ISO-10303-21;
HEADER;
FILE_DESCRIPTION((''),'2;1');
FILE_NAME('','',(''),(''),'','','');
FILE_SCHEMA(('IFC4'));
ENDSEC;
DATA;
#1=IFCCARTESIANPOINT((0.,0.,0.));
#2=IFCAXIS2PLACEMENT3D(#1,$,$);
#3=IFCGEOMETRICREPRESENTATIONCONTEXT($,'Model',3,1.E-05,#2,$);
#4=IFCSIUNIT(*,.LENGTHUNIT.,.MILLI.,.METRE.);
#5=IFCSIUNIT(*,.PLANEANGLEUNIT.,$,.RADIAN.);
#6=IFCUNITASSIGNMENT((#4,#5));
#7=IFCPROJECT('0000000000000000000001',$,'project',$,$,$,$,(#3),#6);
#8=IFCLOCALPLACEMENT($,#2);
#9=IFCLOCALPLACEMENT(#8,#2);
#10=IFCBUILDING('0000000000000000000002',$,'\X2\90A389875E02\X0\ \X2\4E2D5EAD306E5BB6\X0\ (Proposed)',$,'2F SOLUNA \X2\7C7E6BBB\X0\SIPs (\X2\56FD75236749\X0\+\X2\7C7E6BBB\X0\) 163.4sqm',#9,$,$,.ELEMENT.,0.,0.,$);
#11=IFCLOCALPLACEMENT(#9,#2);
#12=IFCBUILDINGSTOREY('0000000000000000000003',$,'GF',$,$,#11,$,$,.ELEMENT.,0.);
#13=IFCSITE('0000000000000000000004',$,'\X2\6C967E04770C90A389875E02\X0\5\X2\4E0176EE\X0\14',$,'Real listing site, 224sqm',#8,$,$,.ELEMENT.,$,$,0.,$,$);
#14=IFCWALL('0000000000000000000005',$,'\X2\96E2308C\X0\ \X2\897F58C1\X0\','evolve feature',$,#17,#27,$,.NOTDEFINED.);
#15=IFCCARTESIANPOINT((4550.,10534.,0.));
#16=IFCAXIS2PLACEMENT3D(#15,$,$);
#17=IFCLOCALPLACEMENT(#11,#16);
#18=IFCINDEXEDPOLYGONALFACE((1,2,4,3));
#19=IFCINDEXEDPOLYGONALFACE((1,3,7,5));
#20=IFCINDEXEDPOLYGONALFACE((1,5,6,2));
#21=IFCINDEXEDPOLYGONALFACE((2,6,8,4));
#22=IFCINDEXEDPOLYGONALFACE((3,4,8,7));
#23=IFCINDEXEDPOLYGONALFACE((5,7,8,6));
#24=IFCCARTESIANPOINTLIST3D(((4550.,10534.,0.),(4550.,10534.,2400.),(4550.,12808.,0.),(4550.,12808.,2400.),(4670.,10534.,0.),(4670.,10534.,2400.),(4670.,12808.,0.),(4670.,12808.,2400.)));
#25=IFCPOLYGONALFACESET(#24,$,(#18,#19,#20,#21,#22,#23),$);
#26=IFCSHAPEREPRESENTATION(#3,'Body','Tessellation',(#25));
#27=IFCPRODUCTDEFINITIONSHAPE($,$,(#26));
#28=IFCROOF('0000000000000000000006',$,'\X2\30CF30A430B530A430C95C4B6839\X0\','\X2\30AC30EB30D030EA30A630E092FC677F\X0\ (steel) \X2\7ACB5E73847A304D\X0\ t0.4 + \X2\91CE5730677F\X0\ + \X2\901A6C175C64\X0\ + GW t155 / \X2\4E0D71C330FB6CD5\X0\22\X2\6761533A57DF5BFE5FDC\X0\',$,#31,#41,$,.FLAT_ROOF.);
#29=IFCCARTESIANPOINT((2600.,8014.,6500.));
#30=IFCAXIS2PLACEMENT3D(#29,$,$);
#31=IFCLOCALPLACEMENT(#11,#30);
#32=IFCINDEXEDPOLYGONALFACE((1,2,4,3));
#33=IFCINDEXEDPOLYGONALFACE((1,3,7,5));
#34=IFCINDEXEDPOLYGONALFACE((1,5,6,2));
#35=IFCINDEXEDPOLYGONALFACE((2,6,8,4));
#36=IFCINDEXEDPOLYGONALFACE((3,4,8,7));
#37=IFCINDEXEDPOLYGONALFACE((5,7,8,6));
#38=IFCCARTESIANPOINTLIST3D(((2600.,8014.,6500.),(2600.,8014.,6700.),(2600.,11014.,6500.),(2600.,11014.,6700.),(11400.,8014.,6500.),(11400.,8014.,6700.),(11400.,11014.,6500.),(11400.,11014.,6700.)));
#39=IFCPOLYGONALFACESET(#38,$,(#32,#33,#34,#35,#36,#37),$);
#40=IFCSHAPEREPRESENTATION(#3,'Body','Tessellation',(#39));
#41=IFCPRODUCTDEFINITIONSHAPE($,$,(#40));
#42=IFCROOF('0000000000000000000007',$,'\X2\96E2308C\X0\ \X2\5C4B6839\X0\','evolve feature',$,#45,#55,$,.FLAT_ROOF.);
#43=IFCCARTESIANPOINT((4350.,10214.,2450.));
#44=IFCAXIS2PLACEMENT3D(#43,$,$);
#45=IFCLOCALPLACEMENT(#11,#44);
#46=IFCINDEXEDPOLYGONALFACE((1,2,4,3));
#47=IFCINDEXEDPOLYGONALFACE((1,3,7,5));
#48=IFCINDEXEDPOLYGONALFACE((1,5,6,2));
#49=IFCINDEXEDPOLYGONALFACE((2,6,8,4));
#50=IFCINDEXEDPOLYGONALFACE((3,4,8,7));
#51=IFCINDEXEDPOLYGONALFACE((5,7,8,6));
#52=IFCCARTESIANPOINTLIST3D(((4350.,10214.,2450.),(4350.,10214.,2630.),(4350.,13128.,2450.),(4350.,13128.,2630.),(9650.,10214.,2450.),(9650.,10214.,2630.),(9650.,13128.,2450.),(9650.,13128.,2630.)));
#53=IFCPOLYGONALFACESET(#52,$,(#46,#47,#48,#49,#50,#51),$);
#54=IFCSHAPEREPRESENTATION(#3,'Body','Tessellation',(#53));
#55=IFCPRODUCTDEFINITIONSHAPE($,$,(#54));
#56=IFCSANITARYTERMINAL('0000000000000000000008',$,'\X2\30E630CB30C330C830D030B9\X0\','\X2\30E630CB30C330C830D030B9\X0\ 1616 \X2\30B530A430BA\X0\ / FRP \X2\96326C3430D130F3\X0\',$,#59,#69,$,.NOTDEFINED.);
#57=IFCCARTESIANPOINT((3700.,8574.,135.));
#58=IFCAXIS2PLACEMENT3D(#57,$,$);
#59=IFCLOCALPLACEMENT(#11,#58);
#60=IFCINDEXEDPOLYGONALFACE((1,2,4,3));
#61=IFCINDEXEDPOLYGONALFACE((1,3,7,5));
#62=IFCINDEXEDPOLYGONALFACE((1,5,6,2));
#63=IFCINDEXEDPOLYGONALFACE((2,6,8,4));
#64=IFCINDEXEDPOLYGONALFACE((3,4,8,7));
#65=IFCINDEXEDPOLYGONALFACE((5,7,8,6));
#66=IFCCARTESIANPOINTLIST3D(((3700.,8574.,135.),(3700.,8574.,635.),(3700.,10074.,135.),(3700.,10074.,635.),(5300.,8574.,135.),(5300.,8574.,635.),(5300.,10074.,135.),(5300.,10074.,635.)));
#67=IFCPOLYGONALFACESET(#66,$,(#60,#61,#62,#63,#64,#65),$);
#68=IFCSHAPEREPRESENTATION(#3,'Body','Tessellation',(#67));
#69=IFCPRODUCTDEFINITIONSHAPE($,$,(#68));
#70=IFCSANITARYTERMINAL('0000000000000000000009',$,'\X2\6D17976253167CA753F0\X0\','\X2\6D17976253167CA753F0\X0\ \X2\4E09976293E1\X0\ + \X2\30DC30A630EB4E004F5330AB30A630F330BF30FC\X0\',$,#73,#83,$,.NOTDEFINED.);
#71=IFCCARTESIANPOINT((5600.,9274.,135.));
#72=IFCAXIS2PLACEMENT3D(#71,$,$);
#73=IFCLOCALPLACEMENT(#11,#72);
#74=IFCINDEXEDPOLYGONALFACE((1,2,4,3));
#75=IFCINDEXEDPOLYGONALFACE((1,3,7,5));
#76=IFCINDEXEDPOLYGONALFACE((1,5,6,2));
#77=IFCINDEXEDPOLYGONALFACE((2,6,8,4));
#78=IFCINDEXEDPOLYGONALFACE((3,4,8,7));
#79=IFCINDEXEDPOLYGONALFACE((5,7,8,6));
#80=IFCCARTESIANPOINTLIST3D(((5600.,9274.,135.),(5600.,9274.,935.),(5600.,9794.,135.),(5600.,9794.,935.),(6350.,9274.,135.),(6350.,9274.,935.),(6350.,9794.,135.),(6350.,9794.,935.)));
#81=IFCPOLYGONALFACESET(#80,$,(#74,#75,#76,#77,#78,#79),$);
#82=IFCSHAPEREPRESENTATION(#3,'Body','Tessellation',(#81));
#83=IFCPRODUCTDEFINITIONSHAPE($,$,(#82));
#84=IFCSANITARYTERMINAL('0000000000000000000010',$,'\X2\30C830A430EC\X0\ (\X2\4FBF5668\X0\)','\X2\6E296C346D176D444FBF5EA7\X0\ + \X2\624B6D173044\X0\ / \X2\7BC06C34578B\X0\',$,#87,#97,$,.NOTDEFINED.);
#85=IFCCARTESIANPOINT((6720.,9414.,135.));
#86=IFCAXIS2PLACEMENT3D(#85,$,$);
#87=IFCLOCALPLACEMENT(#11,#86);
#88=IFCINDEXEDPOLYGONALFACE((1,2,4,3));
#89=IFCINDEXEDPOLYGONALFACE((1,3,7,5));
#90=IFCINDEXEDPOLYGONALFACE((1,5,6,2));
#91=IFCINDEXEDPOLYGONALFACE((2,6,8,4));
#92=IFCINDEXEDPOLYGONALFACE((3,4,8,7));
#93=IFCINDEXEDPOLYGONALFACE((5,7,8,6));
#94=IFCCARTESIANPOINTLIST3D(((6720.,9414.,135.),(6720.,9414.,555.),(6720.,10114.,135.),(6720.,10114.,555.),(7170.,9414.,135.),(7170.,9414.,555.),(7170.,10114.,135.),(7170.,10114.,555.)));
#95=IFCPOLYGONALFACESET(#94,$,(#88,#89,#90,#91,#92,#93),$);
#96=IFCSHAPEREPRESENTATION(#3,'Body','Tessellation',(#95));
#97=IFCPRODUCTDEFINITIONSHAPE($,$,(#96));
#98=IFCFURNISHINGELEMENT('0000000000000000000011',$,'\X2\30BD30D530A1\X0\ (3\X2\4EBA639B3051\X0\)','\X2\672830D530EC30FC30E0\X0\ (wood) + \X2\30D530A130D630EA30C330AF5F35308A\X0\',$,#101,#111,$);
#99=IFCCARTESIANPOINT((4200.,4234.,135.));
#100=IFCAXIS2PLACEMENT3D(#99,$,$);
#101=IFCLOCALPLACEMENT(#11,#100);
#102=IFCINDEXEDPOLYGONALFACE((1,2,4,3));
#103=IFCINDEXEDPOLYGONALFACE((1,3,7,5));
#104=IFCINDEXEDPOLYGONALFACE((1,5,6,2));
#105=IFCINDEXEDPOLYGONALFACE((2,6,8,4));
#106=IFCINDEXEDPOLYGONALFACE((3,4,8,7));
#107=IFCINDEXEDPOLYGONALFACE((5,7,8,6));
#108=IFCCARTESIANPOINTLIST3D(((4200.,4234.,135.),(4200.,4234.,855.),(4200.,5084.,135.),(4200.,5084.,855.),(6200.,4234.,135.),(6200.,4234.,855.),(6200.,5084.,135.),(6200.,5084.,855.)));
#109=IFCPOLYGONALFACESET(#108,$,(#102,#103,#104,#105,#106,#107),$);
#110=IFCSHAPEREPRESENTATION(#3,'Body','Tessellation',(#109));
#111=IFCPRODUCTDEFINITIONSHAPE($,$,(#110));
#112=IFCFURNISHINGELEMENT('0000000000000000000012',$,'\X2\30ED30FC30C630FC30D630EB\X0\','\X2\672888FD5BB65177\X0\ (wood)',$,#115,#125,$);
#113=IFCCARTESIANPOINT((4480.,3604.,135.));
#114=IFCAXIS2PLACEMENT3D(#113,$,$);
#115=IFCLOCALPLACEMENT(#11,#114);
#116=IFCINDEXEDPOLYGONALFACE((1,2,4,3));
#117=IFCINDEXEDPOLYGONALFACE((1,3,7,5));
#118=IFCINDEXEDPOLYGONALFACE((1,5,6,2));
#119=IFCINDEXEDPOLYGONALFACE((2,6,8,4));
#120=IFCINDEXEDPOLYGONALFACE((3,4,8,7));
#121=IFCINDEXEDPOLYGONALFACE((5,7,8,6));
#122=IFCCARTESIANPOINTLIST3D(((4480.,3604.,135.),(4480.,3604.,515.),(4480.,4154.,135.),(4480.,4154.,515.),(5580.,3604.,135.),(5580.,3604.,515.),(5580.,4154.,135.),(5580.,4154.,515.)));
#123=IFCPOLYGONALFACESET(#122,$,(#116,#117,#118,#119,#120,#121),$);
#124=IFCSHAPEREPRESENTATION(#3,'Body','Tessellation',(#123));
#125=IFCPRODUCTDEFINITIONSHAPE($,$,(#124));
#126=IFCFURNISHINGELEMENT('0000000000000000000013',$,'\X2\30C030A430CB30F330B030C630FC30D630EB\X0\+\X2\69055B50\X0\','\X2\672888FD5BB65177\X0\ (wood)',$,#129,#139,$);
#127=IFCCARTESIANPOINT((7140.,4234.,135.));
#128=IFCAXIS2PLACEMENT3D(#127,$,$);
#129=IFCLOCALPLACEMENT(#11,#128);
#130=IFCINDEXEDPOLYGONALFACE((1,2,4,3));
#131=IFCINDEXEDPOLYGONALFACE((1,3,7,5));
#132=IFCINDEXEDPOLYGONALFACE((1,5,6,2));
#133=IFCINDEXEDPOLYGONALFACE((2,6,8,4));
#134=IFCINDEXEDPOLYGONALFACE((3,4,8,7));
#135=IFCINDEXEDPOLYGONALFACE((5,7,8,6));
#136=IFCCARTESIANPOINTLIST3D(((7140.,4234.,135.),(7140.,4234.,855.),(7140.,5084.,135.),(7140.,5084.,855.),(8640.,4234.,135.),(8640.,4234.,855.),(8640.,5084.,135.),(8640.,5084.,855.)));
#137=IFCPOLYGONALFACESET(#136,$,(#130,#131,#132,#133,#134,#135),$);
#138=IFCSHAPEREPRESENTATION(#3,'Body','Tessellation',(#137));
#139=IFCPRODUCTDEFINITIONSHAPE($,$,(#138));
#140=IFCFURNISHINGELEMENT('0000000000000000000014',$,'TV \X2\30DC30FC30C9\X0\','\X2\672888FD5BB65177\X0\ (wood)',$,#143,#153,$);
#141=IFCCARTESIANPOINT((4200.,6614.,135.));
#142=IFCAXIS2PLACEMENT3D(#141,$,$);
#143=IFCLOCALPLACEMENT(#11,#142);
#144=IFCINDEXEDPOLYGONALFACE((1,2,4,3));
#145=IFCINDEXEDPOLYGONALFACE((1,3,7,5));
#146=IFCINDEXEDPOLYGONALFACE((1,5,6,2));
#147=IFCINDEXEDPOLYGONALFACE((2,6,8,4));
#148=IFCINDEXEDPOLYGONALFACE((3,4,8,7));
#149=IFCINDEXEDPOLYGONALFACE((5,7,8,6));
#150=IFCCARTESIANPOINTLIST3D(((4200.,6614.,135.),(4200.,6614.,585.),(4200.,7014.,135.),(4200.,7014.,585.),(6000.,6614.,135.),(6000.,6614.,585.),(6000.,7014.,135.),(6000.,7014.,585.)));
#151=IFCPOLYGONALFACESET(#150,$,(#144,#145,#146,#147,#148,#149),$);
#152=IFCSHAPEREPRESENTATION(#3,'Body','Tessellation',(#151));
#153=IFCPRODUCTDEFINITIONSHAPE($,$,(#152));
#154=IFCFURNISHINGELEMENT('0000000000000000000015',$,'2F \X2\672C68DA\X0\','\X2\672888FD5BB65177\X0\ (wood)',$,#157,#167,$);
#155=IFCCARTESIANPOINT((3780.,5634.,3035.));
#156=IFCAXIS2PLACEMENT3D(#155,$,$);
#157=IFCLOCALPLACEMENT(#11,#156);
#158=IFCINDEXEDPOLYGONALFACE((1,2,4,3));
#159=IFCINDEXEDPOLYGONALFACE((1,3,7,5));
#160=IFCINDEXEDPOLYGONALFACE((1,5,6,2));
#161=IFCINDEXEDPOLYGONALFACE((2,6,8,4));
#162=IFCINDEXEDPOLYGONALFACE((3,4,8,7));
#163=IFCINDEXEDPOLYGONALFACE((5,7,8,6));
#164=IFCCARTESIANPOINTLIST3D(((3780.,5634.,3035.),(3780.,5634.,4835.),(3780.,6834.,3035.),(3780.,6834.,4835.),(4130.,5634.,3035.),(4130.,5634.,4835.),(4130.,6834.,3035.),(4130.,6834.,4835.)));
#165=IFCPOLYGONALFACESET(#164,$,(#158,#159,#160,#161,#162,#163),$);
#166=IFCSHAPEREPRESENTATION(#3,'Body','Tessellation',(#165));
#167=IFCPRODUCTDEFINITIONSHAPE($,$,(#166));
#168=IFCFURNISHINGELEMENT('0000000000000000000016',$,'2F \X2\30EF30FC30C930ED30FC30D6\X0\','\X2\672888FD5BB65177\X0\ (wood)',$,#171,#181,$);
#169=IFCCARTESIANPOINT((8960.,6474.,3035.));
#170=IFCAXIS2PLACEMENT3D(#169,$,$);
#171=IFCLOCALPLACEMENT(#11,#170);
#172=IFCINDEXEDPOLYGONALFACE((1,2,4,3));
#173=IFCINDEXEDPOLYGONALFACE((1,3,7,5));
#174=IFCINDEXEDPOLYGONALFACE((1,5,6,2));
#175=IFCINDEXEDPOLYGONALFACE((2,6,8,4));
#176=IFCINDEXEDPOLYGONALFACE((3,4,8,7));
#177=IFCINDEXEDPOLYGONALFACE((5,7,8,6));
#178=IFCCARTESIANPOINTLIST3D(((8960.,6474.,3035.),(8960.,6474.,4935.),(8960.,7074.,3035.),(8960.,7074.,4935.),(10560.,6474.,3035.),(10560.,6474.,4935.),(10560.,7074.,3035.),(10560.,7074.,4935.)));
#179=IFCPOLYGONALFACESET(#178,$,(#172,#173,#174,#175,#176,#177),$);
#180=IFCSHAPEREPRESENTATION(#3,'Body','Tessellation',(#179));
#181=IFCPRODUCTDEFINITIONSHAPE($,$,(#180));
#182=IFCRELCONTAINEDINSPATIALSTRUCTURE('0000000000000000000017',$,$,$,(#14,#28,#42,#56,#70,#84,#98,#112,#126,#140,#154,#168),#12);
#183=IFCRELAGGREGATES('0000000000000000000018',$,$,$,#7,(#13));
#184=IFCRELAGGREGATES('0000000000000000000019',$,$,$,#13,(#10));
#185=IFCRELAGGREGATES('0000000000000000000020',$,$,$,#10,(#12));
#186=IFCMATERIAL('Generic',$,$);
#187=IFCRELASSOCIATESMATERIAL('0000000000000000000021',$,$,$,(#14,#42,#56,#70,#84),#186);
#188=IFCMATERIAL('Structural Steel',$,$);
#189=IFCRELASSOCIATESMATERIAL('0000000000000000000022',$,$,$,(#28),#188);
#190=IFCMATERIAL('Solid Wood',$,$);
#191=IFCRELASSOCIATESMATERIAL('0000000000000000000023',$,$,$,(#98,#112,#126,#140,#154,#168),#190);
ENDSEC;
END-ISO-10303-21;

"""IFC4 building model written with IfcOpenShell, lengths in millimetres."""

from ifc_helpers import new_model, si_unit, frame, frame_2d, origin, place, context, project, spatial, rectangle, extrude, material, element, save


model = new_model("IFC4")

# Units and contexts
model_context = context("Model", 3, precision=1e-05, world=origin())
ifc_project = project(units=[si_unit("LENGTHUNIT", "METRE", prefix="MILLI"), si_unit("PLANEANGLEUNIT", "RADIAN")], contexts=[model_context])

# Site, building, storey
site_placement = place(None, origin())
site = spatial("IfcSite", under=ifc_project, at=site_placement, Name="沖縄県那覇市5丁目14", ObjectType="Real listing site, 224sqm", CompositionType="ELEMENT", RefElevation=0.0)
building_placement = place(site_placement, origin())
building = spatial("IfcBuilding", under=site, at=building_placement, Name="那覇市 中庭の家 (Proposed)", ObjectType="2F SOLUNA 籾殻SIPs (国産杉+籾殻) 163.4sqm", CompositionType="ELEMENT", ElevationOfRefHeight=0.0, ElevationOfTerrain=0.0)
storey_placement = place(building_placement, origin())
storey = spatial("IfcBuildingStorey", under=building, at=storey_placement, Name="GF", CompositionType="ELEMENT", Elevation=0.0)

# Shared definitions
ifc_material_1 = material(Name="Generic")

# Shared definitions
ifc_material_2 = material(Name="Solid Wood")

# Wall
wall_1_placement = place(storey_placement, frame((4550.0, 10534.0, 0.0)))
element("IfcWall", 1, at=wall_1_placement, inside=storey, material=ifc_material_1, Name="離れ 西壁", Description="evolve feature", PredefinedType="NOTDEFINED", context=model_context, shape_type="SweptSolid", body=[
    extrude(rectangle(XDim=120.0, YDim=2274.0, at=frame_2d((60.0, 1137.0))), frame((4550.0, 10534.0, 0.0)), (0.0, 0.0, 1.0), 2400.0),
])

# Roofs
ifc_material_3 = material(Name="Structural Steel")
roof_1_placement = place(storey_placement, frame((2600.0, 8014.0, 6500.0)))
element("IfcRoof", 2, at=roof_1_placement, inside=storey, material=ifc_material_3, Name="ハイサイド屋根", Description="ガルバリウム鋼板 (steel) 立平葺き t0.4 + 野地板 + 通気層 + GW t155 / 不燃・法22条区域対応", PredefinedType="FLAT_ROOF", context=model_context, shape_type="SweptSolid", body=[
    extrude(rectangle(XDim=8800.0, YDim=3000.0, at=frame_2d((4400.0, 1500.0))), frame((2600.0, 8014.0, 6500.0)), (0.0, 0.0, 1.0), 200.0),
])
roof_2_placement = place(storey_placement, frame((4350.0, 10214.0, 2450.0)))
element("IfcRoof", 3, at=roof_2_placement, inside=storey, material=ifc_material_1, Name="離れ 屋根", Description="evolve feature", PredefinedType="FLAT_ROOF", context=model_context, shape_type="SweptSolid", body=[
    extrude(rectangle(XDim=5300.0, YDim=2914.0, at=frame_2d((2650.0, 1457.0))), frame((4350.0, 10214.0, 2450.0)), (0.0, 0.0, 1.0), 180.0),
])

# Sanitary terminals
sanitary_terminal_1_placement = place(storey_placement, frame((3700.0, 8574.0, 135.0)))
element("IfcSanitaryTerminal", 4, at=sanitary_terminal_1_placement, inside=storey, material=ifc_material_1, Name="ユニットバス", Description="ユニットバス 1616 サイズ / FRP 防水パン", PredefinedType="NOTDEFINED", context=model_context, shape_type="SweptSolid", body=[
    extrude(rectangle(XDim=1600.0, YDim=1500.0, at=frame_2d((800.0, 750.0))), frame((3700.0, 8574.0, 135.0)), (0.0, 0.0, 1.0), 500.0),
])
sanitary_terminal_2_placement = place(storey_placement, frame((5600.0, 9274.0, 135.0)))
element("IfcSanitaryTerminal", 5, at=sanitary_terminal_2_placement, inside=storey, material=ifc_material_1, Name="洗面化粧台", Description="洗面化粧台 三面鏡 + ボウル一体カウンター", PredefinedType="NOTDEFINED", context=model_context, shape_type="SweptSolid", body=[
    extrude(rectangle(XDim=750.0, YDim=520.0, at=frame_2d((375.0, 260.0))), frame((5600.0, 9274.0, 135.0)), (0.0, 0.0, 1.0), 800.0),
])
sanitary_terminal_3_placement = place(storey_placement, frame((6720.0, 9414.0, 135.0)))
element("IfcSanitaryTerminal", 6, at=sanitary_terminal_3_placement, inside=storey, material=ifc_material_1, Name="トイレ (便器)", Description="温水洗浄便座 + 手洗い / 節水型", PredefinedType="NOTDEFINED", context=model_context, shape_type="SweptSolid", body=[
    extrude(rectangle(XDim=450.0, YDim=700.0, at=frame_2d((225.0, 350.0))), frame((6720.0, 9414.0, 135.0)), (0.0, 0.0, 1.0), 420.0),
])

# Furnishing elements
furnishing_1_placement = place(storey_placement, frame((4200.0, 4234.0, 135.0)))
element("IfcFurnishingElement", 7, at=furnishing_1_placement, inside=storey, material=ifc_material_2, Name="ソファ (3人掛け)", Description="木フレーム (wood) + ファブリック張り", context=model_context, shape_type="SweptSolid", body=[
    extrude(rectangle(XDim=2000.0, YDim=850.0, at=frame_2d((1000.0, 425.0))), frame((4200.0, 4234.0, 135.0)), (0.0, 0.0, 1.0), 720.0),
])
furnishing_2_placement = place(storey_placement, frame((4480.0, 3604.0, 135.0)))
element("IfcFurnishingElement", 8, at=furnishing_2_placement, inside=storey, material=ifc_material_2, Name="ローテーブル", Description="木製家具 (wood)", context=model_context, shape_type="SweptSolid", body=[
    extrude(rectangle(XDim=1100.0, YDim=550.0, at=frame_2d((550.0, 275.0))), frame((4480.0, 3604.0, 135.0)), (0.0, 0.0, 1.0), 380.0),
])
furnishing_3_placement = place(storey_placement, frame((7140.0, 4234.0, 135.0)))
element("IfcFurnishingElement", 9, at=furnishing_3_placement, inside=storey, material=ifc_material_2, Name="ダイニングテーブル+椅子", Description="木製家具 (wood)", context=model_context, shape_type="SweptSolid", body=[
    extrude(rectangle(XDim=1500.0, YDim=850.0, at=frame_2d((750.0, 425.0))), frame((7140.0, 4234.0, 135.0)), (0.0, 0.0, 1.0), 720.0),
])
furnishing_4_placement = place(storey_placement, frame((4200.0, 6614.0, 135.0)))
element("IfcFurnishingElement", 10, at=furnishing_4_placement, inside=storey, material=ifc_material_2, Name="TV ボード", Description="木製家具 (wood)", context=model_context, shape_type="SweptSolid", body=[
    extrude(rectangle(XDim=1800.0, YDim=400.0, at=frame_2d((900.0, 200.0))), frame((4200.0, 6614.0, 135.0)), (0.0, 0.0, 1.0), 450.0),
])
furnishing_5_placement = place(storey_placement, frame((3780.0, 5634.0, 3035.0)))
element("IfcFurnishingElement", 11, at=furnishing_5_placement, inside=storey, material=ifc_material_2, Name="2F 本棚", Description="木製家具 (wood)", context=model_context, shape_type="SweptSolid", body=[
    extrude(rectangle(XDim=350.0, YDim=1200.0, at=frame_2d((175.0, 600.0))), frame((3780.0, 5634.0, 3035.0)), (0.0, 0.0, 1.0), 1800.0),
])
furnishing_6_placement = place(storey_placement, frame((8960.0, 6474.0, 3035.0)))
element("IfcFurnishingElement", 12, at=furnishing_6_placement, inside=storey, material=ifc_material_2, Name="2F ワードローブ", Description="木製家具 (wood)", context=model_context, shape_type="SweptSolid", body=[
    extrude(rectangle(XDim=1600.0, YDim=600.0, at=frame_2d((800.0, 300.0))), frame((8960.0, 6474.0, 3035.0)), (0.0, 0.0, 1.0), 1900.0),
])

save(model, "model.ifc")
